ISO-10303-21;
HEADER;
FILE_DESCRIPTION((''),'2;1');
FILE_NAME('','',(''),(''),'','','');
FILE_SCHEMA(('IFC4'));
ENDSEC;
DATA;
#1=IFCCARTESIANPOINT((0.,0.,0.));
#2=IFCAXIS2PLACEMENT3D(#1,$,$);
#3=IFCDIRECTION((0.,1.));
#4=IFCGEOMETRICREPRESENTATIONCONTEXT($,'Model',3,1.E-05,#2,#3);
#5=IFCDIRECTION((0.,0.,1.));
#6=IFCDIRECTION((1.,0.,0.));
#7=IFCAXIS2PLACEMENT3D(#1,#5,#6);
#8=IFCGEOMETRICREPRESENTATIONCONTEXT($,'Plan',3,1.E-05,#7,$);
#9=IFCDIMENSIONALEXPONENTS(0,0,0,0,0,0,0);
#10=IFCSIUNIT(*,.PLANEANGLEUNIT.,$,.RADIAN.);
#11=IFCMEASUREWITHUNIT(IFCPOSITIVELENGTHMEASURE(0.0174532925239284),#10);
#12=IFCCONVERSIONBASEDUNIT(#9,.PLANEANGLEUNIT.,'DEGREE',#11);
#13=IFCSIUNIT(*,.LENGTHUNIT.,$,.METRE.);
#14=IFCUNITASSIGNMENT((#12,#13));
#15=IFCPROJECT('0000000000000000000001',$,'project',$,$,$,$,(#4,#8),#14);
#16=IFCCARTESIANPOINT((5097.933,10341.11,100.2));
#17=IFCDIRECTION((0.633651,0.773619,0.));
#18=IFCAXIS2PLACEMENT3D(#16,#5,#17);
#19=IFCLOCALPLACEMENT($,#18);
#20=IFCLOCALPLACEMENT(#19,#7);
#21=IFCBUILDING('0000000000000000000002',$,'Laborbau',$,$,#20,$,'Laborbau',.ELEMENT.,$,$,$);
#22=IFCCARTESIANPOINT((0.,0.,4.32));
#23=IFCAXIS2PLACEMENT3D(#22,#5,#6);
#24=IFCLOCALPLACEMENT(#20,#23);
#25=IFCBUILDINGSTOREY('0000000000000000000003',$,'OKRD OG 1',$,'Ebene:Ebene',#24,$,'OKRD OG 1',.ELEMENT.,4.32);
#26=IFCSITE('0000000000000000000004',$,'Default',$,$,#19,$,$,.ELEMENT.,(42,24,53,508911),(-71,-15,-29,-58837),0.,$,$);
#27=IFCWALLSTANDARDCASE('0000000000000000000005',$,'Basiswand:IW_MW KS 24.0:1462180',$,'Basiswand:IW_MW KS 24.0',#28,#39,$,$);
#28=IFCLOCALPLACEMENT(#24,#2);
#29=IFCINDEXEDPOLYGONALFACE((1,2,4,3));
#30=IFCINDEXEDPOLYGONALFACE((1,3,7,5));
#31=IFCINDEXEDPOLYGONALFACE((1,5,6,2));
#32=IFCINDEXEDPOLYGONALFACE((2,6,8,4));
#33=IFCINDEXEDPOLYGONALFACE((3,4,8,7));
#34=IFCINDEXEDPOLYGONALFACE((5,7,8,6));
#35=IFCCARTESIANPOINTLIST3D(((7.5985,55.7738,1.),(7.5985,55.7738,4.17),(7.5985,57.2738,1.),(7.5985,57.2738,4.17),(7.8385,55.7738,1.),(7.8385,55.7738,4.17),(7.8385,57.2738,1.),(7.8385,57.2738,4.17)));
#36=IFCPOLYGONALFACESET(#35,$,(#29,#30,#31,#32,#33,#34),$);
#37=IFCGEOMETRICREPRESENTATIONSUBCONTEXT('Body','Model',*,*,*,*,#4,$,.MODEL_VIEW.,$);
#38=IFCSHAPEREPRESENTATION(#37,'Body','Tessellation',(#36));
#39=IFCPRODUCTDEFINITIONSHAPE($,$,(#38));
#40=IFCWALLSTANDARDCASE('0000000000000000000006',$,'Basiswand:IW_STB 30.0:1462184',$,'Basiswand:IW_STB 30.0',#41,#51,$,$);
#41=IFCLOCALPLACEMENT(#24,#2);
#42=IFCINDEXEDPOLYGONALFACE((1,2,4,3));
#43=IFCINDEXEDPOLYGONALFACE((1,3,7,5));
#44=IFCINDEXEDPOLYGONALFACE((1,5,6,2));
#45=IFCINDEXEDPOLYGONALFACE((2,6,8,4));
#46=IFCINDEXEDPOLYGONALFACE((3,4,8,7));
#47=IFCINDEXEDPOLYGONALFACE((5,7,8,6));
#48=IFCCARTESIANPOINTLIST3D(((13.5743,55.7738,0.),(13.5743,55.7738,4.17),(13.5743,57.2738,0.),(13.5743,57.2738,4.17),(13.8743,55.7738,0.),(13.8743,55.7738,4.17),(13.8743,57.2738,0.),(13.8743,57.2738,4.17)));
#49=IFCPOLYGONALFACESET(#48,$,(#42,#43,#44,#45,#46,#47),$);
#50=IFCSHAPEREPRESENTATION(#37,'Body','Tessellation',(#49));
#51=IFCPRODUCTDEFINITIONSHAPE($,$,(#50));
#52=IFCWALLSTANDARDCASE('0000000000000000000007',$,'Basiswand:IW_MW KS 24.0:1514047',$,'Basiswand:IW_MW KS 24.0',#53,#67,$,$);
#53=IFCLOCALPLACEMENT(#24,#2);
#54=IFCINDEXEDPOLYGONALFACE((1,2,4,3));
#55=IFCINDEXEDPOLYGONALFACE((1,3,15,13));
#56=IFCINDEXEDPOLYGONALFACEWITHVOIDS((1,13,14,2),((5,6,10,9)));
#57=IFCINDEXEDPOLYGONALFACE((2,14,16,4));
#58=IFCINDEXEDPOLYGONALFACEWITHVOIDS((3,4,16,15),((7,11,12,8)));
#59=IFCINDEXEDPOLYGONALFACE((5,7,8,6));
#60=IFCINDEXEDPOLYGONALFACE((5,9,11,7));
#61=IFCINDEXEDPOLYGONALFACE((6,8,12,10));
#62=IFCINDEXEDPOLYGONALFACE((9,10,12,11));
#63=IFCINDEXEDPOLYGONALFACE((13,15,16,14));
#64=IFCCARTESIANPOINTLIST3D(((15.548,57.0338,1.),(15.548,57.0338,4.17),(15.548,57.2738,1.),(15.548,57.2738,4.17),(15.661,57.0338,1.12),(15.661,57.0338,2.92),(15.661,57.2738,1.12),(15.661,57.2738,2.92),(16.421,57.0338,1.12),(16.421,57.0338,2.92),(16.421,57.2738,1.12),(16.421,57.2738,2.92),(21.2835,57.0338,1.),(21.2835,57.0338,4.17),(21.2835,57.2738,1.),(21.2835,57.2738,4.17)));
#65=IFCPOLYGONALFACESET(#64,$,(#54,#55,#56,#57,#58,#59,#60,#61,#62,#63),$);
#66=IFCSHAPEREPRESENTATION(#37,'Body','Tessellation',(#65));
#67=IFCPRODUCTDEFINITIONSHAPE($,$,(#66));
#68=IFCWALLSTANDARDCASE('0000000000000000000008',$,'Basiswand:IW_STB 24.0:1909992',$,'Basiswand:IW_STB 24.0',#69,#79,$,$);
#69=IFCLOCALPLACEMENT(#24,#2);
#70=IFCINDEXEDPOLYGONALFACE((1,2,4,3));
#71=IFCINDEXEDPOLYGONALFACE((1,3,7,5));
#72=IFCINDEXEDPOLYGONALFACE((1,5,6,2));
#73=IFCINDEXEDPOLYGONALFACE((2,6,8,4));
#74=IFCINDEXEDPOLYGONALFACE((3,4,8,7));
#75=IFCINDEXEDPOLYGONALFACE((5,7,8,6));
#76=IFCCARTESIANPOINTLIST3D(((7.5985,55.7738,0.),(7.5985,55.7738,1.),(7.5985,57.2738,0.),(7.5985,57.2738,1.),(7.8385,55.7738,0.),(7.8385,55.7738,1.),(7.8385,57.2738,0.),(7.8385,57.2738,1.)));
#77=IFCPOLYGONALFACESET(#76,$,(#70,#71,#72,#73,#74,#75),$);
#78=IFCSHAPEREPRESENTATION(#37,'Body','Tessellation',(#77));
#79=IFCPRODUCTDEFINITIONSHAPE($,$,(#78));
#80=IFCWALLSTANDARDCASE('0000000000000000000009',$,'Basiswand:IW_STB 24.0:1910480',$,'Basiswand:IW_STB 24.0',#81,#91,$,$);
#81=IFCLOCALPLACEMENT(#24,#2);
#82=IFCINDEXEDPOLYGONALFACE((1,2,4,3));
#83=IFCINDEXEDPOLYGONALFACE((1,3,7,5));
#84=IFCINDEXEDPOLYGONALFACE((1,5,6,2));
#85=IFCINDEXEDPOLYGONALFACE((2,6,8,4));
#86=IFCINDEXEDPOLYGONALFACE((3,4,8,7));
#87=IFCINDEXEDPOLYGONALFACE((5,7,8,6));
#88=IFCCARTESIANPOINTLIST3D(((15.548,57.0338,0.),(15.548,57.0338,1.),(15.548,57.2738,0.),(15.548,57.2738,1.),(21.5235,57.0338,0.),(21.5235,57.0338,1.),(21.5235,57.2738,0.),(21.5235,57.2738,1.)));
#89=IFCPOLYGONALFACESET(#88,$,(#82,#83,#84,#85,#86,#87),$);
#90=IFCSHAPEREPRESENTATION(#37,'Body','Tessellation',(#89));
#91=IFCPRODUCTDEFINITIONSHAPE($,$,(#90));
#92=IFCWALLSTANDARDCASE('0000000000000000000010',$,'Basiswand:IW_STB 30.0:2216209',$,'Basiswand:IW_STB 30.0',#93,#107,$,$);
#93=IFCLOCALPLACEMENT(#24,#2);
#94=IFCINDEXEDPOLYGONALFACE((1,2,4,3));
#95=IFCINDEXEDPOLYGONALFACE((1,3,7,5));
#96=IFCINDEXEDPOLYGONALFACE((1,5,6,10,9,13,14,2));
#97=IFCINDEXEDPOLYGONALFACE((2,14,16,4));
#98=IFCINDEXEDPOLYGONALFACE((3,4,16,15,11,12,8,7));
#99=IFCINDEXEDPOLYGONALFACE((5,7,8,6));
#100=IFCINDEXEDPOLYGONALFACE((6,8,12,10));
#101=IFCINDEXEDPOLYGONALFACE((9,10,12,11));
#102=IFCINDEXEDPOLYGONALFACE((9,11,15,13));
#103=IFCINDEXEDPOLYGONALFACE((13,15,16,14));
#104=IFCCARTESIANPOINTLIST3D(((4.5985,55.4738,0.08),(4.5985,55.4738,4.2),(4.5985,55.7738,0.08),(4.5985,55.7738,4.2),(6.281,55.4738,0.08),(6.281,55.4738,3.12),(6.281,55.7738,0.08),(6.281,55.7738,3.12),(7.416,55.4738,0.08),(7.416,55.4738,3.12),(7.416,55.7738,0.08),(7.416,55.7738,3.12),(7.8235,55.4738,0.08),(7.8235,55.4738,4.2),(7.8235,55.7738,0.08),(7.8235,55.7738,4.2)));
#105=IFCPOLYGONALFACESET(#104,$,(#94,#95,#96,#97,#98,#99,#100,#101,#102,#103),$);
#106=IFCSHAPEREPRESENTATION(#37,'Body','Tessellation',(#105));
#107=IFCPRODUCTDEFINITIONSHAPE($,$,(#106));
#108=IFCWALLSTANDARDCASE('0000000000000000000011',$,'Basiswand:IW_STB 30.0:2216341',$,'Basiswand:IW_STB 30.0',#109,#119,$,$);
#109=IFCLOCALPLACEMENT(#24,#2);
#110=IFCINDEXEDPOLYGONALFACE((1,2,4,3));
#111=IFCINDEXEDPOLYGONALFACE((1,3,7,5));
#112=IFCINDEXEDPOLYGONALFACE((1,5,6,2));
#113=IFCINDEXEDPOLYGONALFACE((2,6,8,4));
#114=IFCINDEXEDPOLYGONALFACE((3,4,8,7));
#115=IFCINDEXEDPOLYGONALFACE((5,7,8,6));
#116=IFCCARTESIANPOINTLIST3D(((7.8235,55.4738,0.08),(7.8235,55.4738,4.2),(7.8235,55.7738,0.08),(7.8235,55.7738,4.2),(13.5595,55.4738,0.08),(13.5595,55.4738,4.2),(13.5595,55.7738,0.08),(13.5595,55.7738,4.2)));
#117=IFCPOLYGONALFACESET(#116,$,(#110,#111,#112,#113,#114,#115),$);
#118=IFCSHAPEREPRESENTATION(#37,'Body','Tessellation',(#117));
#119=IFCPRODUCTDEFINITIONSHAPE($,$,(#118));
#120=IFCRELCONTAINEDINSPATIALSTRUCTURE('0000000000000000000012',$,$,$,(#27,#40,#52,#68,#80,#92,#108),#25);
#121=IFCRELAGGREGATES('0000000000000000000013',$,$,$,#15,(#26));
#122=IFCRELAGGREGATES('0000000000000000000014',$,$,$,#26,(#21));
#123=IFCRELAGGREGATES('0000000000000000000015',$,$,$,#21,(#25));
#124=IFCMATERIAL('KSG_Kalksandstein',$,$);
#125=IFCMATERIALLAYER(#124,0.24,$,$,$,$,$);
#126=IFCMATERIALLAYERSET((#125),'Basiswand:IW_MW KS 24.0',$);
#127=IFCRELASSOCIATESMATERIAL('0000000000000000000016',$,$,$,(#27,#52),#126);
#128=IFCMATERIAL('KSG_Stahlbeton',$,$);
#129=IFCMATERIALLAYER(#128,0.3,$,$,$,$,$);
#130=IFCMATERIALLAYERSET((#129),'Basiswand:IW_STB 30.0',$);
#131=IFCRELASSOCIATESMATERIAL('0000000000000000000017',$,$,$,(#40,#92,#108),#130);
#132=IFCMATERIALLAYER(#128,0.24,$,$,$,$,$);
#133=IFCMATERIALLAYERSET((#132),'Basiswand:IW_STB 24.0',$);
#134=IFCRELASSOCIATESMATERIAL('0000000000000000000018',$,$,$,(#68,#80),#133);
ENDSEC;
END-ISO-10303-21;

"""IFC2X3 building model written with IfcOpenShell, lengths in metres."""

from ifc_helpers import new_model, entity, si_unit, converted_unit, direction, frame, frame_2d, origin, origin_with_axes, place, context, subcontext, project, spatial, rectangle, extrude, material, layer, layer_set, layer_usage, element, save


model = new_model("IFC2X3")

# Units and contexts
model_context = context("Model", 3, precision=1e-05, world=origin(), true_north=direction((0.0, 1.0)))
plan_context = context("Plan", 3, precision=1e-05, world=origin_with_axes())
body_context = subcontext(model_context, "Body", "Model", "MODEL_VIEW")
ifc_project = project(units=[converted_unit("PLANEANGLEUNIT", "DEGREE", entity("IfcPositiveLengthMeasure", 0.0174532925239284), si_unit("PLANEANGLEUNIT", "RADIAN"), dimensions=[0, 0, 0, 0, 0, 0, 0]), si_unit("LENGTHUNIT", "METRE")], contexts=[model_context, plan_context])

# Site, building, storey
site_placement = place(None, frame((5097.933, 10341.11, 100.2), z_axis=(0.0, 0.0, 1.0), x_axis=(0.633651, 0.773619, 0.0)))
site = spatial("IfcSite", under=ifc_project, at=site_placement, Name="Default", CompositionType="ELEMENT", RefLatitude=(42, 24, 53, 508911), RefLongitude=(-71, -15, -29, -58837), RefElevation=0.0)
building_placement = place(site_placement, origin_with_axes())
building = spatial("IfcBuilding", under=site, at=building_placement, Name="Laborbau", LongName="Laborbau", CompositionType="ELEMENT")
storey_placement = place(building_placement, frame((0.0, 0.0, 4.32), z_axis=(0.0, 0.0, 1.0), x_axis=(1.0, 0.0, 0.0)))
storey = spatial("IfcBuildingStorey", under=building, at=storey_placement, Name="OKRD OG 1", ObjectType="Ebene:Ebene", LongName="OKRD OG 1", CompositionType="ELEMENT", Elevation=4.32)

# Walls
ifc_material_1 = material(Name="KSG_Kalksandstein")
ifc_layer_1 = layer(ifc_material_1, 0.24)
ifc_layer_set_1 = layer_set([ifc_layer_1], Name="Basiswand:IW_MW KS 24.0")
ifc_layer_usage_1 = layer_usage(ifc_layer_set_1, "AXIS2", "NEGATIVE", 0.12)
wall_1_placement = place(storey_placement, frame((7.7185, 55.7738, 1.0), z_axis=(0.0, 0.0, 1.0), x_axis=(0.0, 1.0, 0.0)))
element("IfcWallStandardCase", 1, at=wall_1_placement, inside=storey, material=ifc_layer_usage_1, Name="Basiswand:IW_MW KS 24.0:1462180", ObjectType="Basiswand:IW_MW KS 24.0", context=body_context, shape_type="SweptSolid", body=[
    extrude(rectangle(XDim=1.5, YDim=0.24, at=frame_2d((0.75, 0.0), x_axis=(-1.0, 0.0))), origin(), (0.0, 0.0, 1.0), 3.17),
])
ifc_material_2 = material(Name="KSG_Stahlbeton")
ifc_layer_2 = layer(ifc_material_2, 0.3)
ifc_layer_set_2 = layer_set([ifc_layer_2], Name="Basiswand:IW_STB 30.0")
ifc_layer_usage_2 = layer_usage(ifc_layer_set_2, "AXIS2", "NEGATIVE", 0.15)
wall_2_placement = place(storey_placement, frame((13.7243, 57.2738, 0.0), z_axis=(0.0, 0.0, 1.0), x_axis=(0.0, -1.0, 0.0)))
element("IfcWallStandardCase", 2, at=wall_2_placement, inside=storey, material=ifc_layer_usage_2, Name="Basiswand:IW_STB 30.0:1462184", ObjectType="Basiswand:IW_STB 30.0", context=body_context, shape_type="SweptSolid", body=[
    extrude(rectangle(XDim=1.5, YDim=0.3, at=frame_2d((0.75, 0.0), x_axis=(-1.0, 0.0))), origin(), (0.0, 0.0, 1.0), 4.17),
])

# Wall, openings
ifc_layer_usage_3 = layer_usage(ifc_layer_set_1, "AXIS2", "NEGATIVE", 0.12)
wall_3_placement = place(storey_placement, frame((15.548, 57.1538, 1.0), z_axis=(0.0, 0.0, 1.0), x_axis=(1.0, 0.0, 0.0)))
wall_3 = element("IfcWallStandardCase", 3, at=wall_3_placement, inside=storey, material=ifc_layer_usage_3, Name="Basiswand:IW_MW KS 24.0:1514047", ObjectType="Basiswand:IW_MW KS 24.0", context=body_context, shape_type="SweptSolid", body=[
    extrude(rectangle(XDim=5.7355, YDim=0.24, at=frame_2d((2.8677, 0.0), x_axis=(-1.0, 0.0))), origin(), (0.0, 0.0, 1.0), 3.17),
])
opening_1_placement = place(wall_3_placement, frame((-15.548, -57.1538, -1.0), z_axis=(0.0, 0.0, 1.0), x_axis=(1.0, 0.0, 0.0)))
element("IfcOpeningElement", 4, at=opening_1_placement, cuts=wall_3, ObjectType="Opening", context=body_context, shape_type="SweptSolid", body=[
    extrude(rectangle(XDim=1.8, YDim=0.76, at=frame_2d((0.0, 0.0), x_axis=(0.0, 1.0))), frame((16.041, 55.5098, 2.02), z_axis=(0.0, 1.0, 0.0), x_axis=(-1.0, 0.0, 0.0)), (0.0, 0.0, 1.0), 3.048),
])
opening_2_placement = place(wall_3_placement, frame((0.113, -0.12, 0.12), z_axis=(0.0, 0.0, 1.0), x_axis=(1.0, 0.0, 0.0)))
element("IfcOpeningElement", 5, at=opening_2_placement, cuts=wall_3, ObjectType="Opening", context=body_context, shape_type="SweptSolid", body=[
    extrude(rectangle(XDim=1.8, YDim=0.76, at=frame_2d((0.9, 0.38), x_axis=(1.0, 0.0))), frame((0.0, 0.0, 0.0), z_axis=(0.0, 1.0, 0.0), x_axis=(0.0, 0.0, 1.0)), (0.0, 0.0, 1.0), 0.24),
])

# Walls
ifc_layer_3 = layer(ifc_material_2, 0.24)
ifc_layer_set_3 = layer_set([ifc_layer_3], Name="Basiswand:IW_STB 24.0")
ifc_layer_usage_4 = layer_usage(ifc_layer_set_3, "AXIS2", "NEGATIVE", 0.12)
wall_4_placement = place(storey_placement, frame((7.7185, 55.7738, 0.0), z_axis=(0.0, 0.0, 1.0), x_axis=(0.0, 1.0, 0.0)))
element("IfcWallStandardCase", 6, at=wall_4_placement, inside=storey, material=ifc_layer_usage_4, Name="Basiswand:IW_STB 24.0:1909992", ObjectType="Basiswand:IW_STB 24.0", context=body_context, shape_type="SweptSolid", body=[
    extrude(rectangle(XDim=1.5, YDim=0.24, at=frame_2d((0.75, 0.0), x_axis=(-1.0, 0.0))), origin(), (0.0, 0.0, 1.0), 1.0),
])
ifc_layer_usage_5 = layer_usage(ifc_layer_set_3, "AXIS2", "NEGATIVE", 0.12)
wall_5_placement = place(storey_placement, frame((15.548, 57.1538, 0.0), z_axis=(0.0, 0.0, 1.0), x_axis=(1.0, 0.0, 0.0)))
element("IfcWallStandardCase", 7, at=wall_5_placement, inside=storey, material=ifc_layer_usage_5, Name="Basiswand:IW_STB 24.0:1910480", ObjectType="Basiswand:IW_STB 24.0", context=body_context, shape_type="SweptSolid", body=[
    extrude(rectangle(XDim=5.9755, YDim=0.24, at=frame_2d((2.9877, 0.0), x_axis=(-1.0, 0.0))), origin(), (0.0, 0.0, 1.0), 1.0),
])

# Wall, openings
ifc_layer_usage_6 = layer_usage(ifc_layer_set_2, "AXIS2", "NEGATIVE", 0.15)
wall_6_placement = place(storey_placement, frame((7.8235, 55.6238, 0.08), z_axis=(0.0, 0.0, 1.0), x_axis=(-1.0, 0.0, 0.0)))
wall_6 = element("IfcWallStandardCase", 8, at=wall_6_placement, inside=storey, material=ifc_layer_usage_6, Name="Basiswand:IW_STB 30.0:2216209", ObjectType="Basiswand:IW_STB 30.0", context=body_context, shape_type="SweptSolid", body=[
    extrude(rectangle(XDim=3.225, YDim=0.3, at=frame_2d((1.6125, 0.0), x_axis=(-1.0, 0.0))), origin(), (0.0, 0.0, 1.0), 4.12),
])
opening_3_placement = place(wall_6_placement, frame((1.5425, 0.15, 0.0), z_axis=(0.0, 0.0, 1.0), x_axis=(1.0, 0.0, 0.0)))
element("IfcOpeningElement", 9, at=opening_3_placement, cuts=wall_6, ObjectType="Opening", context=body_context, shape_type="SweptSolid", body=[
    extrude(rectangle(XDim=3.04, YDim=1.135, at=frame_2d((1.52, 0.5675), x_axis=(1.0, 0.0))), frame((0.0, 0.0, 0.0), z_axis=(0.0, -1.0, 0.0), x_axis=(0.0, 0.0, 1.0)), (0.0, 0.0, 1.0), 0.3),
])
opening_4_placement = place(wall_6_placement, frame((7.8235, 55.6238, -0.08), z_axis=(0.0, 0.0, 1.0), x_axis=(-1.0, 0.0, 0.0)))
element("IfcOpeningElement", 10, at=opening_4_placement, cuts=wall_6, ObjectType="Opening", context=body_context, shape_type="SweptSolid", body=[
    extrude(rectangle(XDim=3.04, YDim=1.135, at=frame_2d((0.0, 0.0), x_axis=(1.0, 0.0))), frame((6.8485, 57.2978, 1.6), z_axis=(0.0, -1.0, 0.0), x_axis=(0.0, 0.0, 1.0)), (0.0, 0.0, 1.0), 3.048),
])

# Wall
ifc_layer_usage_7 = layer_usage(ifc_layer_set_2, "AXIS2", "NEGATIVE", 0.15)
wall_7_placement = place(storey_placement, frame((13.5595, 55.6238, 0.08), z_axis=(0.0, 0.0, 1.0), x_axis=(-1.0, 0.0, 0.0)))
element("IfcWallStandardCase", 11, at=wall_7_placement, inside=storey, material=ifc_layer_usage_7, Name="Basiswand:IW_STB 30.0:2216341", ObjectType="Basiswand:IW_STB 30.0", context=body_context, shape_type="SweptSolid", body=[
    extrude(rectangle(XDim=5.736, YDim=0.3, at=frame_2d((2.868, 0.0), x_axis=(-1.0, 0.0))), origin(), (0.0, 0.0, 1.0), 4.12),
])

save(model, "model.ifc")
